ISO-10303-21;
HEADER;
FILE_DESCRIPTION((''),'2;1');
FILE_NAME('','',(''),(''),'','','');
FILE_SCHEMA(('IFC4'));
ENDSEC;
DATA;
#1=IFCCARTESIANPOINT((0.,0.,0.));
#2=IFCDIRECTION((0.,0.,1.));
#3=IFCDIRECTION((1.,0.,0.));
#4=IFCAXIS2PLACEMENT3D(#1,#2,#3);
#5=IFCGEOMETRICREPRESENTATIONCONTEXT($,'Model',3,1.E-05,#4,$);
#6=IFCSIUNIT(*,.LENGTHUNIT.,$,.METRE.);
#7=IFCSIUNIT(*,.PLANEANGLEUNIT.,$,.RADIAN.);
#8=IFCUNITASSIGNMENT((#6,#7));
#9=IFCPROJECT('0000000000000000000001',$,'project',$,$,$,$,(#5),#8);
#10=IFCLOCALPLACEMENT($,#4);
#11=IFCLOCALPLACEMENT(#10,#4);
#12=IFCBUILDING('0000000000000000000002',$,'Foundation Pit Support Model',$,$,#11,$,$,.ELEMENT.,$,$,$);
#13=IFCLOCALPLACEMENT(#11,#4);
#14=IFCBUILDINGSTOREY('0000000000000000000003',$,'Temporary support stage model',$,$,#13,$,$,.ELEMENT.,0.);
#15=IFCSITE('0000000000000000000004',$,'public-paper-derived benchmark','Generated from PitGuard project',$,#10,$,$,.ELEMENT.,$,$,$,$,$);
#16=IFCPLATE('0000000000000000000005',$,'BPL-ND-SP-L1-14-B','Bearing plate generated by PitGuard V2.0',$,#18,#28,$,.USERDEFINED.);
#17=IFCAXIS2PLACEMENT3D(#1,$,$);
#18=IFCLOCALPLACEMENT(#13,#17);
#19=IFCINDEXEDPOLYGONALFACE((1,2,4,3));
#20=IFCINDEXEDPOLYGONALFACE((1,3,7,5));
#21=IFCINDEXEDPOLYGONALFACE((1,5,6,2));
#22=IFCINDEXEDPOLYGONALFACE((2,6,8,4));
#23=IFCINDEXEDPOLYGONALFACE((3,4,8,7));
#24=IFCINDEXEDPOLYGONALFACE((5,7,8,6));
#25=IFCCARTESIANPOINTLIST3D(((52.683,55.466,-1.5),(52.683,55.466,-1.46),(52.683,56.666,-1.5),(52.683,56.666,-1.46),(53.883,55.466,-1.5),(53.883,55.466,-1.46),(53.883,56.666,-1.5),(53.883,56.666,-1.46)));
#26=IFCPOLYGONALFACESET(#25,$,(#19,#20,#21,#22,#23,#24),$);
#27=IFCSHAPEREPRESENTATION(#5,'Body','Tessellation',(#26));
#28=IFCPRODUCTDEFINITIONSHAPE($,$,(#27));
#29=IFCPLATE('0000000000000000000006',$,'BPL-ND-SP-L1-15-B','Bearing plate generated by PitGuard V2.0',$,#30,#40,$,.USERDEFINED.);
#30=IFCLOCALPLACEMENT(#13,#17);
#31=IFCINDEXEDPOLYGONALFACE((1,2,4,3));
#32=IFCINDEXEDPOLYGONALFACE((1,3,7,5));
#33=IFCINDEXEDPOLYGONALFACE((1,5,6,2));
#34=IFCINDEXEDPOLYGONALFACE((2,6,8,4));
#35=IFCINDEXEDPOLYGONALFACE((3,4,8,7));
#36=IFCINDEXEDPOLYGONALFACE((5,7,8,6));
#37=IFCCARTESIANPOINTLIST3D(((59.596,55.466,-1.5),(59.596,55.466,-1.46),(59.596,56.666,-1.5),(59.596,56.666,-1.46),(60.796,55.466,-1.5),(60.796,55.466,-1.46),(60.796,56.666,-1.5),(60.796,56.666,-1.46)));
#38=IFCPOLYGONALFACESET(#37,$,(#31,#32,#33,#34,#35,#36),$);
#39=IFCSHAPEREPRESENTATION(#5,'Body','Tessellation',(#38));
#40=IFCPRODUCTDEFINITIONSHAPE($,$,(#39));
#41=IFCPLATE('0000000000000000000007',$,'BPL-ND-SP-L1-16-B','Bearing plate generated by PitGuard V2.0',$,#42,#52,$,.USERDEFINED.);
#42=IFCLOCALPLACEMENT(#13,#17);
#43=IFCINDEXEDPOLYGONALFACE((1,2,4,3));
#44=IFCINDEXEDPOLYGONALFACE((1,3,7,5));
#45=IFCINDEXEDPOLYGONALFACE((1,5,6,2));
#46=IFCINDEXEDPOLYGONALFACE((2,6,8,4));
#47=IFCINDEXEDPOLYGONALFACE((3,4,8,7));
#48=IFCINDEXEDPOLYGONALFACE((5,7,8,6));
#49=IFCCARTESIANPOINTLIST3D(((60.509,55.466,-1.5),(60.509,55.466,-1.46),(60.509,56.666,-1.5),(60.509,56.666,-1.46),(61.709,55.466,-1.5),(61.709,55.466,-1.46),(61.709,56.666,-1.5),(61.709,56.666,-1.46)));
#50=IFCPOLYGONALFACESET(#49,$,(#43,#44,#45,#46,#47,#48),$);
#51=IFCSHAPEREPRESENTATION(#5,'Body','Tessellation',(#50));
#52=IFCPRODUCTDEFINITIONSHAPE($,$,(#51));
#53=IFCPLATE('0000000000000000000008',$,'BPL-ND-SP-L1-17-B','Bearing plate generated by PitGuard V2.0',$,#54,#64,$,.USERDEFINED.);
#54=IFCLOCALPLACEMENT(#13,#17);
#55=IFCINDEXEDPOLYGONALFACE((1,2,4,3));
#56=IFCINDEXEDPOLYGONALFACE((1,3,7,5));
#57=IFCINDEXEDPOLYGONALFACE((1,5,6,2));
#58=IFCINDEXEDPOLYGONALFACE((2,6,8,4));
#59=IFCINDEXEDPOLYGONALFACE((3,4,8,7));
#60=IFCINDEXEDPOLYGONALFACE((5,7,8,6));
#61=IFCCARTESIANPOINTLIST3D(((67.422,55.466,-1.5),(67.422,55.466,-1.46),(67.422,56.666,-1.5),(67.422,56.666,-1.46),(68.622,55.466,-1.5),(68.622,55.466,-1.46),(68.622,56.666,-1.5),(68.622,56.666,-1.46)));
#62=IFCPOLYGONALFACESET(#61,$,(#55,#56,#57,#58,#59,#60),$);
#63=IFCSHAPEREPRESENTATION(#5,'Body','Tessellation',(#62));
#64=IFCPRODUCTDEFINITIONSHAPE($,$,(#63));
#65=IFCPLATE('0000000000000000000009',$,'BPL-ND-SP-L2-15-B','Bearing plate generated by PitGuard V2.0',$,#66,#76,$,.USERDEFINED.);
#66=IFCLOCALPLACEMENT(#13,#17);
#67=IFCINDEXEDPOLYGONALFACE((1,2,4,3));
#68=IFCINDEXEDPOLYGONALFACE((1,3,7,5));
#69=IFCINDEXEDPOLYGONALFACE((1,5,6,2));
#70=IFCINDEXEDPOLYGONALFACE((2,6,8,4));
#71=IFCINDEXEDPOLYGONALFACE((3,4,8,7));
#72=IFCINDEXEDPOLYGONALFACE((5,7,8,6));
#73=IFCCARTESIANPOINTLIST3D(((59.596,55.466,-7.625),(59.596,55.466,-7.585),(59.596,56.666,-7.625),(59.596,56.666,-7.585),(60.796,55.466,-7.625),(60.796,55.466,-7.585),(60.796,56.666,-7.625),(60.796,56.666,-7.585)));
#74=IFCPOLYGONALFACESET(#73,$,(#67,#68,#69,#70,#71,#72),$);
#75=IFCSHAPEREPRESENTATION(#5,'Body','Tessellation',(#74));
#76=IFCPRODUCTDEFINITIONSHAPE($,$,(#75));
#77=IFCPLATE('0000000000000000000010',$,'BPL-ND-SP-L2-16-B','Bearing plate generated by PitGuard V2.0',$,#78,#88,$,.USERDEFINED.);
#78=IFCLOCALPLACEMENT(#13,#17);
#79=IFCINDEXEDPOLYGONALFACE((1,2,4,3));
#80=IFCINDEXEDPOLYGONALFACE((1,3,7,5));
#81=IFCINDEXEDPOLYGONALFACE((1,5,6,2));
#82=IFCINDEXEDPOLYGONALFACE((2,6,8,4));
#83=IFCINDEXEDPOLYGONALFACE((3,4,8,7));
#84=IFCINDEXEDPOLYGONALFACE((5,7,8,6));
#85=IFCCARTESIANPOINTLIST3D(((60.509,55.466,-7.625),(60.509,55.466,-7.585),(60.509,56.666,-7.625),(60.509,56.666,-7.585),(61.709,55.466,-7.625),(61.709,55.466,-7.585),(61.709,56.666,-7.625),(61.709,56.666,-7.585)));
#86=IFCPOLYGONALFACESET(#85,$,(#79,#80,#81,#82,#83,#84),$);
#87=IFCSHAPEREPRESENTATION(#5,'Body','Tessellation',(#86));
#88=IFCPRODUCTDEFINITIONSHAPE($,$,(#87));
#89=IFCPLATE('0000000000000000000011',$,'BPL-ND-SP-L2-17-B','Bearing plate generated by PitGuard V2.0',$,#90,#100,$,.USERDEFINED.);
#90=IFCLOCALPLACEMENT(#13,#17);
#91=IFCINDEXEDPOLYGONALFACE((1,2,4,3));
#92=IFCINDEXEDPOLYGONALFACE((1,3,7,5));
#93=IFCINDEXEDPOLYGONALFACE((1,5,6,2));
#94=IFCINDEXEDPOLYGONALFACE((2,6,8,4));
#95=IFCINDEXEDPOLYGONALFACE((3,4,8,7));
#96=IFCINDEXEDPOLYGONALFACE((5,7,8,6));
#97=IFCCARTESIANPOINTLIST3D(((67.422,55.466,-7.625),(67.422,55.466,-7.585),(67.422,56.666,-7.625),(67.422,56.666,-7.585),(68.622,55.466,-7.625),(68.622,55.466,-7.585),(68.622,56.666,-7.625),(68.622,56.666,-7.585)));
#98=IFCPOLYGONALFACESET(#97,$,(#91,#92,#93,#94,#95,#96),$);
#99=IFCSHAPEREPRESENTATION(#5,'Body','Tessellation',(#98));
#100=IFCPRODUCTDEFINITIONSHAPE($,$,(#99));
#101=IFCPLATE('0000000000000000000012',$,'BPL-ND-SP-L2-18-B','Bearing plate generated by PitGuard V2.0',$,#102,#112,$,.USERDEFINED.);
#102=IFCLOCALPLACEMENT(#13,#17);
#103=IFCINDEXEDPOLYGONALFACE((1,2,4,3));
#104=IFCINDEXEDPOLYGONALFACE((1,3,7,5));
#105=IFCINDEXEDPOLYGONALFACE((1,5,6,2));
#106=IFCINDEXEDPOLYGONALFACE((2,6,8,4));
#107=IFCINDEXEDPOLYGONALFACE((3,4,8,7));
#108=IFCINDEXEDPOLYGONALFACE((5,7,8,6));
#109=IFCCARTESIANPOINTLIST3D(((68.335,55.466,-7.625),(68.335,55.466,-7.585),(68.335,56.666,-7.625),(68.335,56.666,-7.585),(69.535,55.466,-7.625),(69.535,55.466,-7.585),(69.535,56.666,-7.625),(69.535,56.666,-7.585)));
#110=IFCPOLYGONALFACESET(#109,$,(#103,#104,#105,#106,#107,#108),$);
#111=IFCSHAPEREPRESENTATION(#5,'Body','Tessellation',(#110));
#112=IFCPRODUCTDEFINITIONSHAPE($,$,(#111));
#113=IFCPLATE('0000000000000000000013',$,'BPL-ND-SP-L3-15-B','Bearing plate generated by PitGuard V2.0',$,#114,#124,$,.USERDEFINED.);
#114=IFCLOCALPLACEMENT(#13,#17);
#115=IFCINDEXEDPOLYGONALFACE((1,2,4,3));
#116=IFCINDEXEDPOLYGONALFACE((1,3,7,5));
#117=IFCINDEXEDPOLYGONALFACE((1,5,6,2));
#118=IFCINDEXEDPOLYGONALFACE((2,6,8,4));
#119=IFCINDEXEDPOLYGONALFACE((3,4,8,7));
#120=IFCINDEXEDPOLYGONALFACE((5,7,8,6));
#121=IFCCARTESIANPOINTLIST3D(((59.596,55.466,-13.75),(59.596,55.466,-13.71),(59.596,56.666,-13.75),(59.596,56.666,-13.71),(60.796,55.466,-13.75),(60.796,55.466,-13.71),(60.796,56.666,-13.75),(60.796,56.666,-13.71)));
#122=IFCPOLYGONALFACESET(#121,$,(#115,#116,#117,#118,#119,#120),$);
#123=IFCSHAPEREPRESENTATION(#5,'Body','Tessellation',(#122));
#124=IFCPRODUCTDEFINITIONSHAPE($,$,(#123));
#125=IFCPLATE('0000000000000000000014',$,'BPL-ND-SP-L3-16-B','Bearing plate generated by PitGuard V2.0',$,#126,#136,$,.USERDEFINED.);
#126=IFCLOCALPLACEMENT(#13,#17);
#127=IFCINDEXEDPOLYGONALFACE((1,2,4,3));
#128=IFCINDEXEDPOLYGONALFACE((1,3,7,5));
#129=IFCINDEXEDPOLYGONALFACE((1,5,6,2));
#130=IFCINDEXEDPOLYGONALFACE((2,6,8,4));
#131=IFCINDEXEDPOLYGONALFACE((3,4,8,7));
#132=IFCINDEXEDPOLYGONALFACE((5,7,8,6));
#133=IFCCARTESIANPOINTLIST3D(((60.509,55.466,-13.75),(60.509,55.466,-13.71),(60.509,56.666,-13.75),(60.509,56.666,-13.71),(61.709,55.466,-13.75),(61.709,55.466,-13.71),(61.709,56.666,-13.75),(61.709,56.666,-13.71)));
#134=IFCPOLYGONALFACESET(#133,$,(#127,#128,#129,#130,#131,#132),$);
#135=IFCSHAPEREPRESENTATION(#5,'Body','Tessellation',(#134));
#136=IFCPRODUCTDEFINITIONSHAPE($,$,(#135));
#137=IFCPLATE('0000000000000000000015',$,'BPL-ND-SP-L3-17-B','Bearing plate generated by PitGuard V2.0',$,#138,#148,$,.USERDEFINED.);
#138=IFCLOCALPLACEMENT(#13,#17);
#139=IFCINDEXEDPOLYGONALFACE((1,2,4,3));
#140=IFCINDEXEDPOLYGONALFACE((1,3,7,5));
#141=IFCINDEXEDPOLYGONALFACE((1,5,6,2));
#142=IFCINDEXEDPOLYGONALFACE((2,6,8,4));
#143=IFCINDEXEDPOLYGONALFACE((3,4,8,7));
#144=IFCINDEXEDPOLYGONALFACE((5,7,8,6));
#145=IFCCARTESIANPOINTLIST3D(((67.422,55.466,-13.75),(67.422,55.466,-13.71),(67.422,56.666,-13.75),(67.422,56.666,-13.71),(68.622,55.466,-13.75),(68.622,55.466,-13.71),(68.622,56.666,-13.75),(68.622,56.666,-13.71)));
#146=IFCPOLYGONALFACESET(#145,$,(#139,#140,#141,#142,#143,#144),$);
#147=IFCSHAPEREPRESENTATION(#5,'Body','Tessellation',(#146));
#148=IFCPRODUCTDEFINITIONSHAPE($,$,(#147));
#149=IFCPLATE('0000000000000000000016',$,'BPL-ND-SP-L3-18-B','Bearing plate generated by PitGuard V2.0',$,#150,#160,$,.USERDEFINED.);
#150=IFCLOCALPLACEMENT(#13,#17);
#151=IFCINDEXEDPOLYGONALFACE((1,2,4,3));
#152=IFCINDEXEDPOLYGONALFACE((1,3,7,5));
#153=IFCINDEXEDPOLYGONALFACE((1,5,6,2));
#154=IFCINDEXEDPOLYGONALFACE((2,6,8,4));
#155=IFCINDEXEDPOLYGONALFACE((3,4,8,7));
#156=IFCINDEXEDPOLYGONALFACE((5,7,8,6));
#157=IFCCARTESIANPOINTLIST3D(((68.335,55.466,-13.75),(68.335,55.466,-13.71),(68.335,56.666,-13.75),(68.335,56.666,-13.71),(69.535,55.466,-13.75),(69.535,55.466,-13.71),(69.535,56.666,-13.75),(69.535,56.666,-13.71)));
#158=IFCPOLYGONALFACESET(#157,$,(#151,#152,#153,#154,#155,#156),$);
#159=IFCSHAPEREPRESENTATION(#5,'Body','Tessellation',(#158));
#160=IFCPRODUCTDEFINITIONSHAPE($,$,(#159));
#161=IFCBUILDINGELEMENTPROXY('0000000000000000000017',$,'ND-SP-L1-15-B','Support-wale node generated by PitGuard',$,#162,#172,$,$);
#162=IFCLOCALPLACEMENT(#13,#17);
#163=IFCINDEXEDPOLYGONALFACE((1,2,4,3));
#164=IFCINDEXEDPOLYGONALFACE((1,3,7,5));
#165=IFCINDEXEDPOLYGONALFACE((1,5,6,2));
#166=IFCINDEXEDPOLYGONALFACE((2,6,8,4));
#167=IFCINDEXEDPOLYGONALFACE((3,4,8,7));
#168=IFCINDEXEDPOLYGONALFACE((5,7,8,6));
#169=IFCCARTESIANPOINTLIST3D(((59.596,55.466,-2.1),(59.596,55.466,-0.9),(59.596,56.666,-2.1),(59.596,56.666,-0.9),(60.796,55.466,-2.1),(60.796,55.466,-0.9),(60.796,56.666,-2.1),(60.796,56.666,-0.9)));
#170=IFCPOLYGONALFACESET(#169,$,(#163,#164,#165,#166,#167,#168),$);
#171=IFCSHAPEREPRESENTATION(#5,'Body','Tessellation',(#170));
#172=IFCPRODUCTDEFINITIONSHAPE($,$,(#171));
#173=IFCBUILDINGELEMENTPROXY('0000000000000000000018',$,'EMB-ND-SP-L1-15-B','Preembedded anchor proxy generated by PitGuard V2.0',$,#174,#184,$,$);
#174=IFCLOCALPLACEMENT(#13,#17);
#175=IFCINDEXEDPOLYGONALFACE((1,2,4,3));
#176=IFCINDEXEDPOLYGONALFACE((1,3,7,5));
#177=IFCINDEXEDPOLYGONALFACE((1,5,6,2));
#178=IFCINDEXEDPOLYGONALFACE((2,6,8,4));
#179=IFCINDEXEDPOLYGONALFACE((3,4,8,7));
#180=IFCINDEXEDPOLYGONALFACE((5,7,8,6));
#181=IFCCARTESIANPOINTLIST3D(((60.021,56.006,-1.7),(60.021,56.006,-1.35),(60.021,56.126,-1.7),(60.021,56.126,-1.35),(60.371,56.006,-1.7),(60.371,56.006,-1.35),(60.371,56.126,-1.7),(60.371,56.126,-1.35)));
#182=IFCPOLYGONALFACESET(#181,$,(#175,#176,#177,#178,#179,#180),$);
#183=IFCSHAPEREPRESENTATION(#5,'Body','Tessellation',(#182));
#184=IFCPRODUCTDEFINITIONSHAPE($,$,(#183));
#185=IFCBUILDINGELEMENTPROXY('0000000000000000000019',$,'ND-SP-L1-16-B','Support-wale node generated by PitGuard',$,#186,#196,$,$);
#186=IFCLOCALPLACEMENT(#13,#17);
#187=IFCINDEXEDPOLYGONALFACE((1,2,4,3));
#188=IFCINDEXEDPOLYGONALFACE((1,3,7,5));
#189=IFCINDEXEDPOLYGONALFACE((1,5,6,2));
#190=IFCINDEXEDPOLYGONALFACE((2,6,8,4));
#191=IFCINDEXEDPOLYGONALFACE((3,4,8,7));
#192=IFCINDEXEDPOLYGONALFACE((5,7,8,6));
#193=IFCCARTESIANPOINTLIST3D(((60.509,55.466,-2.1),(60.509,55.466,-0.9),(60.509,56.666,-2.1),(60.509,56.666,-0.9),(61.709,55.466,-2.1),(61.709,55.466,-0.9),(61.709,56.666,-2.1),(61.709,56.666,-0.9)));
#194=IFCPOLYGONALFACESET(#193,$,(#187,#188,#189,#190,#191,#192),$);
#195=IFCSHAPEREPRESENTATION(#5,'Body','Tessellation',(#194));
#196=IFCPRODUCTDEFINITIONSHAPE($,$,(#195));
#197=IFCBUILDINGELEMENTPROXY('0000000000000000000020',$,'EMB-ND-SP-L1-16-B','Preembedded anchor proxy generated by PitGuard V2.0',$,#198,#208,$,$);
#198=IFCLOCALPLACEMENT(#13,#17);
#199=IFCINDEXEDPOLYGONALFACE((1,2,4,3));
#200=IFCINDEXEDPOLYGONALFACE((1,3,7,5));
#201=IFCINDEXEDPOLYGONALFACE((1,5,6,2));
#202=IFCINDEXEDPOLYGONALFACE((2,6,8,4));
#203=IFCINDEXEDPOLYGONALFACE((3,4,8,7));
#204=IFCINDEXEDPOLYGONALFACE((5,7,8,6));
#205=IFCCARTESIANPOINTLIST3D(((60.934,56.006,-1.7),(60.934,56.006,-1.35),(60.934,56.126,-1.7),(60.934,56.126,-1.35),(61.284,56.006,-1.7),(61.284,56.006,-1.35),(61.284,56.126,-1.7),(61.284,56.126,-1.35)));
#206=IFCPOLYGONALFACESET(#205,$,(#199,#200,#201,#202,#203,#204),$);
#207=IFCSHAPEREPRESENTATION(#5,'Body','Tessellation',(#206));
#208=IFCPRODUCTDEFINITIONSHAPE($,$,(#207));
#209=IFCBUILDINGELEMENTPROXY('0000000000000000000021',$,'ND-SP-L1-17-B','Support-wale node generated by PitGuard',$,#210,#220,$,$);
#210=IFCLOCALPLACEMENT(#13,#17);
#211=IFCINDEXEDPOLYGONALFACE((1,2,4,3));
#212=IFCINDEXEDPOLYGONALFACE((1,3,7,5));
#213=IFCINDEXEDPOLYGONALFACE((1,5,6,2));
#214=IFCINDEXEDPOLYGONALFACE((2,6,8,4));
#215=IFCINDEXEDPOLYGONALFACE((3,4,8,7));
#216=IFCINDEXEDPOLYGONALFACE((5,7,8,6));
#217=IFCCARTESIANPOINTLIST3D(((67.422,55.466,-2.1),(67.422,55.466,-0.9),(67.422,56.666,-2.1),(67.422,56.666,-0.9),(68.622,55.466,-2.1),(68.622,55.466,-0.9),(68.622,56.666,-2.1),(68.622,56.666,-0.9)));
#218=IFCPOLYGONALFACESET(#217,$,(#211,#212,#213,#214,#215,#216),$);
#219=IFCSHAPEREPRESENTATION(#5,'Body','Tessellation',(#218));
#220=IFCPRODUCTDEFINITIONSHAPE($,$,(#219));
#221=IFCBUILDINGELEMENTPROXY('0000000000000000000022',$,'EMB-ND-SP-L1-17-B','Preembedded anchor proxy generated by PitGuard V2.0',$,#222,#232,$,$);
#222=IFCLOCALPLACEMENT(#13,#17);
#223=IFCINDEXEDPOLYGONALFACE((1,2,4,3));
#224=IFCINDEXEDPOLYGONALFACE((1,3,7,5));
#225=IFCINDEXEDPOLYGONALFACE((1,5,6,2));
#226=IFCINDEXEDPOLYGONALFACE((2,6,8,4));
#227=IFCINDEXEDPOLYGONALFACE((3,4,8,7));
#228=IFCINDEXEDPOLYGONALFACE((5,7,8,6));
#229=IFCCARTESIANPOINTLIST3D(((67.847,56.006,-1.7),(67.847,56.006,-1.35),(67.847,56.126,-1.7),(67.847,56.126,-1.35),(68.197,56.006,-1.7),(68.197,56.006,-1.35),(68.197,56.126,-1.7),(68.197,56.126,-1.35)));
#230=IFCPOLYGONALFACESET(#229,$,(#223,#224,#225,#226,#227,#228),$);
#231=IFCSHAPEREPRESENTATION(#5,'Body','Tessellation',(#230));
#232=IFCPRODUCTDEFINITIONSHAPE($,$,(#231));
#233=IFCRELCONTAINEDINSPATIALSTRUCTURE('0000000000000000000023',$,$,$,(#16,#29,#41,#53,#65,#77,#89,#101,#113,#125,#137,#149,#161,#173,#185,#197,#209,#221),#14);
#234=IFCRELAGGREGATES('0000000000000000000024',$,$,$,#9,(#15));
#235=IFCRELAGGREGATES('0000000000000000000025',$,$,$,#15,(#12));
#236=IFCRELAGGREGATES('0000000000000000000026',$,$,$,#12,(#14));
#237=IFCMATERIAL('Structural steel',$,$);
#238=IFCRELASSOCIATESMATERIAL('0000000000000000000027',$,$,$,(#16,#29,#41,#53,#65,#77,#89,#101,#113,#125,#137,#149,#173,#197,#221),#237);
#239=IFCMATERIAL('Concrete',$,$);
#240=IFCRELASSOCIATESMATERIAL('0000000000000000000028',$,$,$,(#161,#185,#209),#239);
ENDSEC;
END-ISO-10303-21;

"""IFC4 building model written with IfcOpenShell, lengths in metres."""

from ifc_helpers import new_model, si_unit, frame, origin_with_axes, origin_2d, place, context, project, spatial, rectangle, extrude, material, element, save


model = new_model("IFC4")

# Units and contexts
model_context = context("Model", 3, precision=1e-05, world=origin_with_axes())
ifc_project = project(units=[si_unit("LENGTHUNIT", "METRE"), si_unit("PLANEANGLEUNIT", "RADIAN")], contexts=[model_context])

# Site, building, storey
site_placement = place(None, origin_with_axes())
site = spatial("IfcSite", under=ifc_project, at=site_placement, Name="public-paper-derived benchmark", Description="Generated from PitGuard project", CompositionType="ELEMENT")
building_placement = place(site_placement, origin_with_axes())
building = spatial("IfcBuilding", under=site, at=building_placement, Name="Foundation Pit Support Model", CompositionType="ELEMENT")
storey_placement = place(building_placement, origin_with_axes())
storey = spatial("IfcBuildingStorey", under=building, at=storey_placement, Name="Temporary support stage model", CompositionType="ELEMENT", Elevation=0.0)

# Plates
ifc_material_1 = material(Name="Structural steel")
for number, where, z_axis, x_axis, name in (
    (1, (53.283, 56.066, -1.5), (0.0, 0.0, 1.0), (1.0, 0.0, 0.0), "BPL-ND-SP-L1-14-B"),
    (2, (60.196, 56.066, -1.5), (0.0, 0.0, 1.0), (1.0, 0.0, 0.0), "BPL-ND-SP-L1-15-B"),
    (3, (61.109, 56.066, -1.5), (0.0, 0.0, 1.0), (1.0, 0.0, 0.0), "BPL-ND-SP-L1-16-B"),
    (4, (68.022, 56.066, -1.5), (0.0, 0.0, 1.0), (1.0, 0.0, 0.0), "BPL-ND-SP-L1-17-B"),
    (5, (60.196, 56.066, -7.625), (0.0, 0.0, 1.0), (1.0, 0.0, 0.0), "BPL-ND-SP-L2-15-B"),
    (6, (61.109, 56.066, -7.625), (0.0, 0.0, 1.0), (1.0, 0.0, 0.0), "BPL-ND-SP-L2-16-B"),
    (7, (68.022, 56.066, -7.625), (0.0, 0.0, 1.0), (1.0, 0.0, 0.0), "BPL-ND-SP-L2-17-B"),
    (8, (68.935, 56.066, -7.625), (0.0, 0.0, 1.0), (1.0, 0.0, 0.0), "BPL-ND-SP-L2-18-B"),
    (9, (60.196, 56.066, -13.75), (0.0, 0.0, 1.0), (1.0, 0.0, 0.0), "BPL-ND-SP-L3-15-B"),
    (10, (61.109, 56.066, -13.75), (0.0, 0.0, 1.0), (1.0, 0.0, 0.0), "BPL-ND-SP-L3-16-B"),
    (11, (68.022, 56.066, -13.75), (0.0, 0.0, 1.0), (1.0, 0.0, 0.0), "BPL-ND-SP-L3-17-B"),
    (12, (68.935, 56.066, -13.75), (0.0, 0.0, 1.0), (1.0, 0.0, 0.0), "BPL-ND-SP-L3-18-B"),
):
    element("IfcPlate", number, at=place(storey_placement, frame(where, z_axis=z_axis, x_axis=x_axis)), inside=storey, material=ifc_material_1, Name=name, Description="Bearing plate generated by PitGuard V2.0", PredefinedType="USERDEFINED", context=model_context, shape_type="SweptSolid", body=[
        extrude(rectangle(XDim=1.2, YDim=1.2, at=origin_2d()), origin_with_axes(), (0.0, 0.0, 1.0), 0.04),
    ])

# Building element proxies
ifc_material_2 = material(Name="Concrete")
proxy_1_placement = place(storey_placement, frame((60.196, 56.066, -2.1), z_axis=(0.0, 0.0, 1.0), x_axis=(1.0, 0.0, 0.0)))
element("IfcBuildingElementProxy", 13, at=proxy_1_placement, inside=storey, material=ifc_material_2, Name="ND-SP-L1-15-B", Description="Support-wale node generated by PitGuard", context=model_context, shape_type="SweptSolid", body=[
    extrude(rectangle(XDim=1.2, YDim=1.2, at=origin_2d()), origin_with_axes(), (0.0, 0.0, 1.0), 1.2),
])
proxy_2_placement = place(storey_placement, frame((60.196, 56.066, -1.7), z_axis=(0.0, 0.0, 1.0), x_axis=(1.0, 0.0, 0.0)))
element("IfcBuildingElementProxy", 14, at=proxy_2_placement, inside=storey, material=ifc_material_1, Name="EMB-ND-SP-L1-15-B", Description="Preembedded anchor proxy generated by PitGuard V2.0", context=model_context, shape_type="SweptSolid", body=[
    extrude(rectangle(XDim=0.35, YDim=0.12, at=origin_2d()), origin_with_axes(), (0.0, 0.0, 1.0), 0.35),
])
proxy_3_placement = place(storey_placement, frame((61.109, 56.066, -2.1), z_axis=(0.0, 0.0, 1.0), x_axis=(1.0, 0.0, 0.0)))
element("IfcBuildingElementProxy", 15, at=proxy_3_placement, inside=storey, material=ifc_material_2, Name="ND-SP-L1-16-B", Description="Support-wale node generated by PitGuard", context=model_context, shape_type="SweptSolid", body=[
    extrude(rectangle(XDim=1.2, YDim=1.2, at=origin_2d()), origin_with_axes(), (0.0, 0.0, 1.0), 1.2),
])
proxy_4_placement = place(storey_placement, frame((61.109, 56.066, -1.7), z_axis=(0.0, 0.0, 1.0), x_axis=(1.0, 0.0, 0.0)))
element("IfcBuildingElementProxy", 16, at=proxy_4_placement, inside=storey, material=ifc_material_1, Name="EMB-ND-SP-L1-16-B", Description="Preembedded anchor proxy generated by PitGuard V2.0", context=model_context, shape_type="SweptSolid", body=[
    extrude(rectangle(XDim=0.35, YDim=0.12, at=origin_2d()), origin_with_axes(), (0.0, 0.0, 1.0), 0.35),
])
proxy_5_placement = place(storey_placement, frame((68.022, 56.066, -2.1), z_axis=(0.0, 0.0, 1.0), x_axis=(1.0, 0.0, 0.0)))
element("IfcBuildingElementProxy", 17, at=proxy_5_placement, inside=storey, material=ifc_material_2, Name="ND-SP-L1-17-B", Description="Support-wale node generated by PitGuard", context=model_context, shape_type="SweptSolid", body=[
    extrude(rectangle(XDim=1.2, YDim=1.2, at=origin_2d()), origin_with_axes(), (0.0, 0.0, 1.0), 1.2),
])
proxy_6_placement = place(storey_placement, frame((68.022, 56.066, -1.7), z_axis=(0.0, 0.0, 1.0), x_axis=(1.0, 0.0, 0.0)))
element("IfcBuildingElementProxy", 18, at=proxy_6_placement, inside=storey, material=ifc_material_1, Name="EMB-ND-SP-L1-17-B", Description="Preembedded anchor proxy generated by PitGuard V2.0", context=model_context, shape_type="SweptSolid", body=[
    extrude(rectangle(XDim=0.35, YDim=0.12, at=origin_2d()), origin_with_axes(), (0.0, 0.0, 1.0), 0.35),
])

save(model, "model.ifc")
